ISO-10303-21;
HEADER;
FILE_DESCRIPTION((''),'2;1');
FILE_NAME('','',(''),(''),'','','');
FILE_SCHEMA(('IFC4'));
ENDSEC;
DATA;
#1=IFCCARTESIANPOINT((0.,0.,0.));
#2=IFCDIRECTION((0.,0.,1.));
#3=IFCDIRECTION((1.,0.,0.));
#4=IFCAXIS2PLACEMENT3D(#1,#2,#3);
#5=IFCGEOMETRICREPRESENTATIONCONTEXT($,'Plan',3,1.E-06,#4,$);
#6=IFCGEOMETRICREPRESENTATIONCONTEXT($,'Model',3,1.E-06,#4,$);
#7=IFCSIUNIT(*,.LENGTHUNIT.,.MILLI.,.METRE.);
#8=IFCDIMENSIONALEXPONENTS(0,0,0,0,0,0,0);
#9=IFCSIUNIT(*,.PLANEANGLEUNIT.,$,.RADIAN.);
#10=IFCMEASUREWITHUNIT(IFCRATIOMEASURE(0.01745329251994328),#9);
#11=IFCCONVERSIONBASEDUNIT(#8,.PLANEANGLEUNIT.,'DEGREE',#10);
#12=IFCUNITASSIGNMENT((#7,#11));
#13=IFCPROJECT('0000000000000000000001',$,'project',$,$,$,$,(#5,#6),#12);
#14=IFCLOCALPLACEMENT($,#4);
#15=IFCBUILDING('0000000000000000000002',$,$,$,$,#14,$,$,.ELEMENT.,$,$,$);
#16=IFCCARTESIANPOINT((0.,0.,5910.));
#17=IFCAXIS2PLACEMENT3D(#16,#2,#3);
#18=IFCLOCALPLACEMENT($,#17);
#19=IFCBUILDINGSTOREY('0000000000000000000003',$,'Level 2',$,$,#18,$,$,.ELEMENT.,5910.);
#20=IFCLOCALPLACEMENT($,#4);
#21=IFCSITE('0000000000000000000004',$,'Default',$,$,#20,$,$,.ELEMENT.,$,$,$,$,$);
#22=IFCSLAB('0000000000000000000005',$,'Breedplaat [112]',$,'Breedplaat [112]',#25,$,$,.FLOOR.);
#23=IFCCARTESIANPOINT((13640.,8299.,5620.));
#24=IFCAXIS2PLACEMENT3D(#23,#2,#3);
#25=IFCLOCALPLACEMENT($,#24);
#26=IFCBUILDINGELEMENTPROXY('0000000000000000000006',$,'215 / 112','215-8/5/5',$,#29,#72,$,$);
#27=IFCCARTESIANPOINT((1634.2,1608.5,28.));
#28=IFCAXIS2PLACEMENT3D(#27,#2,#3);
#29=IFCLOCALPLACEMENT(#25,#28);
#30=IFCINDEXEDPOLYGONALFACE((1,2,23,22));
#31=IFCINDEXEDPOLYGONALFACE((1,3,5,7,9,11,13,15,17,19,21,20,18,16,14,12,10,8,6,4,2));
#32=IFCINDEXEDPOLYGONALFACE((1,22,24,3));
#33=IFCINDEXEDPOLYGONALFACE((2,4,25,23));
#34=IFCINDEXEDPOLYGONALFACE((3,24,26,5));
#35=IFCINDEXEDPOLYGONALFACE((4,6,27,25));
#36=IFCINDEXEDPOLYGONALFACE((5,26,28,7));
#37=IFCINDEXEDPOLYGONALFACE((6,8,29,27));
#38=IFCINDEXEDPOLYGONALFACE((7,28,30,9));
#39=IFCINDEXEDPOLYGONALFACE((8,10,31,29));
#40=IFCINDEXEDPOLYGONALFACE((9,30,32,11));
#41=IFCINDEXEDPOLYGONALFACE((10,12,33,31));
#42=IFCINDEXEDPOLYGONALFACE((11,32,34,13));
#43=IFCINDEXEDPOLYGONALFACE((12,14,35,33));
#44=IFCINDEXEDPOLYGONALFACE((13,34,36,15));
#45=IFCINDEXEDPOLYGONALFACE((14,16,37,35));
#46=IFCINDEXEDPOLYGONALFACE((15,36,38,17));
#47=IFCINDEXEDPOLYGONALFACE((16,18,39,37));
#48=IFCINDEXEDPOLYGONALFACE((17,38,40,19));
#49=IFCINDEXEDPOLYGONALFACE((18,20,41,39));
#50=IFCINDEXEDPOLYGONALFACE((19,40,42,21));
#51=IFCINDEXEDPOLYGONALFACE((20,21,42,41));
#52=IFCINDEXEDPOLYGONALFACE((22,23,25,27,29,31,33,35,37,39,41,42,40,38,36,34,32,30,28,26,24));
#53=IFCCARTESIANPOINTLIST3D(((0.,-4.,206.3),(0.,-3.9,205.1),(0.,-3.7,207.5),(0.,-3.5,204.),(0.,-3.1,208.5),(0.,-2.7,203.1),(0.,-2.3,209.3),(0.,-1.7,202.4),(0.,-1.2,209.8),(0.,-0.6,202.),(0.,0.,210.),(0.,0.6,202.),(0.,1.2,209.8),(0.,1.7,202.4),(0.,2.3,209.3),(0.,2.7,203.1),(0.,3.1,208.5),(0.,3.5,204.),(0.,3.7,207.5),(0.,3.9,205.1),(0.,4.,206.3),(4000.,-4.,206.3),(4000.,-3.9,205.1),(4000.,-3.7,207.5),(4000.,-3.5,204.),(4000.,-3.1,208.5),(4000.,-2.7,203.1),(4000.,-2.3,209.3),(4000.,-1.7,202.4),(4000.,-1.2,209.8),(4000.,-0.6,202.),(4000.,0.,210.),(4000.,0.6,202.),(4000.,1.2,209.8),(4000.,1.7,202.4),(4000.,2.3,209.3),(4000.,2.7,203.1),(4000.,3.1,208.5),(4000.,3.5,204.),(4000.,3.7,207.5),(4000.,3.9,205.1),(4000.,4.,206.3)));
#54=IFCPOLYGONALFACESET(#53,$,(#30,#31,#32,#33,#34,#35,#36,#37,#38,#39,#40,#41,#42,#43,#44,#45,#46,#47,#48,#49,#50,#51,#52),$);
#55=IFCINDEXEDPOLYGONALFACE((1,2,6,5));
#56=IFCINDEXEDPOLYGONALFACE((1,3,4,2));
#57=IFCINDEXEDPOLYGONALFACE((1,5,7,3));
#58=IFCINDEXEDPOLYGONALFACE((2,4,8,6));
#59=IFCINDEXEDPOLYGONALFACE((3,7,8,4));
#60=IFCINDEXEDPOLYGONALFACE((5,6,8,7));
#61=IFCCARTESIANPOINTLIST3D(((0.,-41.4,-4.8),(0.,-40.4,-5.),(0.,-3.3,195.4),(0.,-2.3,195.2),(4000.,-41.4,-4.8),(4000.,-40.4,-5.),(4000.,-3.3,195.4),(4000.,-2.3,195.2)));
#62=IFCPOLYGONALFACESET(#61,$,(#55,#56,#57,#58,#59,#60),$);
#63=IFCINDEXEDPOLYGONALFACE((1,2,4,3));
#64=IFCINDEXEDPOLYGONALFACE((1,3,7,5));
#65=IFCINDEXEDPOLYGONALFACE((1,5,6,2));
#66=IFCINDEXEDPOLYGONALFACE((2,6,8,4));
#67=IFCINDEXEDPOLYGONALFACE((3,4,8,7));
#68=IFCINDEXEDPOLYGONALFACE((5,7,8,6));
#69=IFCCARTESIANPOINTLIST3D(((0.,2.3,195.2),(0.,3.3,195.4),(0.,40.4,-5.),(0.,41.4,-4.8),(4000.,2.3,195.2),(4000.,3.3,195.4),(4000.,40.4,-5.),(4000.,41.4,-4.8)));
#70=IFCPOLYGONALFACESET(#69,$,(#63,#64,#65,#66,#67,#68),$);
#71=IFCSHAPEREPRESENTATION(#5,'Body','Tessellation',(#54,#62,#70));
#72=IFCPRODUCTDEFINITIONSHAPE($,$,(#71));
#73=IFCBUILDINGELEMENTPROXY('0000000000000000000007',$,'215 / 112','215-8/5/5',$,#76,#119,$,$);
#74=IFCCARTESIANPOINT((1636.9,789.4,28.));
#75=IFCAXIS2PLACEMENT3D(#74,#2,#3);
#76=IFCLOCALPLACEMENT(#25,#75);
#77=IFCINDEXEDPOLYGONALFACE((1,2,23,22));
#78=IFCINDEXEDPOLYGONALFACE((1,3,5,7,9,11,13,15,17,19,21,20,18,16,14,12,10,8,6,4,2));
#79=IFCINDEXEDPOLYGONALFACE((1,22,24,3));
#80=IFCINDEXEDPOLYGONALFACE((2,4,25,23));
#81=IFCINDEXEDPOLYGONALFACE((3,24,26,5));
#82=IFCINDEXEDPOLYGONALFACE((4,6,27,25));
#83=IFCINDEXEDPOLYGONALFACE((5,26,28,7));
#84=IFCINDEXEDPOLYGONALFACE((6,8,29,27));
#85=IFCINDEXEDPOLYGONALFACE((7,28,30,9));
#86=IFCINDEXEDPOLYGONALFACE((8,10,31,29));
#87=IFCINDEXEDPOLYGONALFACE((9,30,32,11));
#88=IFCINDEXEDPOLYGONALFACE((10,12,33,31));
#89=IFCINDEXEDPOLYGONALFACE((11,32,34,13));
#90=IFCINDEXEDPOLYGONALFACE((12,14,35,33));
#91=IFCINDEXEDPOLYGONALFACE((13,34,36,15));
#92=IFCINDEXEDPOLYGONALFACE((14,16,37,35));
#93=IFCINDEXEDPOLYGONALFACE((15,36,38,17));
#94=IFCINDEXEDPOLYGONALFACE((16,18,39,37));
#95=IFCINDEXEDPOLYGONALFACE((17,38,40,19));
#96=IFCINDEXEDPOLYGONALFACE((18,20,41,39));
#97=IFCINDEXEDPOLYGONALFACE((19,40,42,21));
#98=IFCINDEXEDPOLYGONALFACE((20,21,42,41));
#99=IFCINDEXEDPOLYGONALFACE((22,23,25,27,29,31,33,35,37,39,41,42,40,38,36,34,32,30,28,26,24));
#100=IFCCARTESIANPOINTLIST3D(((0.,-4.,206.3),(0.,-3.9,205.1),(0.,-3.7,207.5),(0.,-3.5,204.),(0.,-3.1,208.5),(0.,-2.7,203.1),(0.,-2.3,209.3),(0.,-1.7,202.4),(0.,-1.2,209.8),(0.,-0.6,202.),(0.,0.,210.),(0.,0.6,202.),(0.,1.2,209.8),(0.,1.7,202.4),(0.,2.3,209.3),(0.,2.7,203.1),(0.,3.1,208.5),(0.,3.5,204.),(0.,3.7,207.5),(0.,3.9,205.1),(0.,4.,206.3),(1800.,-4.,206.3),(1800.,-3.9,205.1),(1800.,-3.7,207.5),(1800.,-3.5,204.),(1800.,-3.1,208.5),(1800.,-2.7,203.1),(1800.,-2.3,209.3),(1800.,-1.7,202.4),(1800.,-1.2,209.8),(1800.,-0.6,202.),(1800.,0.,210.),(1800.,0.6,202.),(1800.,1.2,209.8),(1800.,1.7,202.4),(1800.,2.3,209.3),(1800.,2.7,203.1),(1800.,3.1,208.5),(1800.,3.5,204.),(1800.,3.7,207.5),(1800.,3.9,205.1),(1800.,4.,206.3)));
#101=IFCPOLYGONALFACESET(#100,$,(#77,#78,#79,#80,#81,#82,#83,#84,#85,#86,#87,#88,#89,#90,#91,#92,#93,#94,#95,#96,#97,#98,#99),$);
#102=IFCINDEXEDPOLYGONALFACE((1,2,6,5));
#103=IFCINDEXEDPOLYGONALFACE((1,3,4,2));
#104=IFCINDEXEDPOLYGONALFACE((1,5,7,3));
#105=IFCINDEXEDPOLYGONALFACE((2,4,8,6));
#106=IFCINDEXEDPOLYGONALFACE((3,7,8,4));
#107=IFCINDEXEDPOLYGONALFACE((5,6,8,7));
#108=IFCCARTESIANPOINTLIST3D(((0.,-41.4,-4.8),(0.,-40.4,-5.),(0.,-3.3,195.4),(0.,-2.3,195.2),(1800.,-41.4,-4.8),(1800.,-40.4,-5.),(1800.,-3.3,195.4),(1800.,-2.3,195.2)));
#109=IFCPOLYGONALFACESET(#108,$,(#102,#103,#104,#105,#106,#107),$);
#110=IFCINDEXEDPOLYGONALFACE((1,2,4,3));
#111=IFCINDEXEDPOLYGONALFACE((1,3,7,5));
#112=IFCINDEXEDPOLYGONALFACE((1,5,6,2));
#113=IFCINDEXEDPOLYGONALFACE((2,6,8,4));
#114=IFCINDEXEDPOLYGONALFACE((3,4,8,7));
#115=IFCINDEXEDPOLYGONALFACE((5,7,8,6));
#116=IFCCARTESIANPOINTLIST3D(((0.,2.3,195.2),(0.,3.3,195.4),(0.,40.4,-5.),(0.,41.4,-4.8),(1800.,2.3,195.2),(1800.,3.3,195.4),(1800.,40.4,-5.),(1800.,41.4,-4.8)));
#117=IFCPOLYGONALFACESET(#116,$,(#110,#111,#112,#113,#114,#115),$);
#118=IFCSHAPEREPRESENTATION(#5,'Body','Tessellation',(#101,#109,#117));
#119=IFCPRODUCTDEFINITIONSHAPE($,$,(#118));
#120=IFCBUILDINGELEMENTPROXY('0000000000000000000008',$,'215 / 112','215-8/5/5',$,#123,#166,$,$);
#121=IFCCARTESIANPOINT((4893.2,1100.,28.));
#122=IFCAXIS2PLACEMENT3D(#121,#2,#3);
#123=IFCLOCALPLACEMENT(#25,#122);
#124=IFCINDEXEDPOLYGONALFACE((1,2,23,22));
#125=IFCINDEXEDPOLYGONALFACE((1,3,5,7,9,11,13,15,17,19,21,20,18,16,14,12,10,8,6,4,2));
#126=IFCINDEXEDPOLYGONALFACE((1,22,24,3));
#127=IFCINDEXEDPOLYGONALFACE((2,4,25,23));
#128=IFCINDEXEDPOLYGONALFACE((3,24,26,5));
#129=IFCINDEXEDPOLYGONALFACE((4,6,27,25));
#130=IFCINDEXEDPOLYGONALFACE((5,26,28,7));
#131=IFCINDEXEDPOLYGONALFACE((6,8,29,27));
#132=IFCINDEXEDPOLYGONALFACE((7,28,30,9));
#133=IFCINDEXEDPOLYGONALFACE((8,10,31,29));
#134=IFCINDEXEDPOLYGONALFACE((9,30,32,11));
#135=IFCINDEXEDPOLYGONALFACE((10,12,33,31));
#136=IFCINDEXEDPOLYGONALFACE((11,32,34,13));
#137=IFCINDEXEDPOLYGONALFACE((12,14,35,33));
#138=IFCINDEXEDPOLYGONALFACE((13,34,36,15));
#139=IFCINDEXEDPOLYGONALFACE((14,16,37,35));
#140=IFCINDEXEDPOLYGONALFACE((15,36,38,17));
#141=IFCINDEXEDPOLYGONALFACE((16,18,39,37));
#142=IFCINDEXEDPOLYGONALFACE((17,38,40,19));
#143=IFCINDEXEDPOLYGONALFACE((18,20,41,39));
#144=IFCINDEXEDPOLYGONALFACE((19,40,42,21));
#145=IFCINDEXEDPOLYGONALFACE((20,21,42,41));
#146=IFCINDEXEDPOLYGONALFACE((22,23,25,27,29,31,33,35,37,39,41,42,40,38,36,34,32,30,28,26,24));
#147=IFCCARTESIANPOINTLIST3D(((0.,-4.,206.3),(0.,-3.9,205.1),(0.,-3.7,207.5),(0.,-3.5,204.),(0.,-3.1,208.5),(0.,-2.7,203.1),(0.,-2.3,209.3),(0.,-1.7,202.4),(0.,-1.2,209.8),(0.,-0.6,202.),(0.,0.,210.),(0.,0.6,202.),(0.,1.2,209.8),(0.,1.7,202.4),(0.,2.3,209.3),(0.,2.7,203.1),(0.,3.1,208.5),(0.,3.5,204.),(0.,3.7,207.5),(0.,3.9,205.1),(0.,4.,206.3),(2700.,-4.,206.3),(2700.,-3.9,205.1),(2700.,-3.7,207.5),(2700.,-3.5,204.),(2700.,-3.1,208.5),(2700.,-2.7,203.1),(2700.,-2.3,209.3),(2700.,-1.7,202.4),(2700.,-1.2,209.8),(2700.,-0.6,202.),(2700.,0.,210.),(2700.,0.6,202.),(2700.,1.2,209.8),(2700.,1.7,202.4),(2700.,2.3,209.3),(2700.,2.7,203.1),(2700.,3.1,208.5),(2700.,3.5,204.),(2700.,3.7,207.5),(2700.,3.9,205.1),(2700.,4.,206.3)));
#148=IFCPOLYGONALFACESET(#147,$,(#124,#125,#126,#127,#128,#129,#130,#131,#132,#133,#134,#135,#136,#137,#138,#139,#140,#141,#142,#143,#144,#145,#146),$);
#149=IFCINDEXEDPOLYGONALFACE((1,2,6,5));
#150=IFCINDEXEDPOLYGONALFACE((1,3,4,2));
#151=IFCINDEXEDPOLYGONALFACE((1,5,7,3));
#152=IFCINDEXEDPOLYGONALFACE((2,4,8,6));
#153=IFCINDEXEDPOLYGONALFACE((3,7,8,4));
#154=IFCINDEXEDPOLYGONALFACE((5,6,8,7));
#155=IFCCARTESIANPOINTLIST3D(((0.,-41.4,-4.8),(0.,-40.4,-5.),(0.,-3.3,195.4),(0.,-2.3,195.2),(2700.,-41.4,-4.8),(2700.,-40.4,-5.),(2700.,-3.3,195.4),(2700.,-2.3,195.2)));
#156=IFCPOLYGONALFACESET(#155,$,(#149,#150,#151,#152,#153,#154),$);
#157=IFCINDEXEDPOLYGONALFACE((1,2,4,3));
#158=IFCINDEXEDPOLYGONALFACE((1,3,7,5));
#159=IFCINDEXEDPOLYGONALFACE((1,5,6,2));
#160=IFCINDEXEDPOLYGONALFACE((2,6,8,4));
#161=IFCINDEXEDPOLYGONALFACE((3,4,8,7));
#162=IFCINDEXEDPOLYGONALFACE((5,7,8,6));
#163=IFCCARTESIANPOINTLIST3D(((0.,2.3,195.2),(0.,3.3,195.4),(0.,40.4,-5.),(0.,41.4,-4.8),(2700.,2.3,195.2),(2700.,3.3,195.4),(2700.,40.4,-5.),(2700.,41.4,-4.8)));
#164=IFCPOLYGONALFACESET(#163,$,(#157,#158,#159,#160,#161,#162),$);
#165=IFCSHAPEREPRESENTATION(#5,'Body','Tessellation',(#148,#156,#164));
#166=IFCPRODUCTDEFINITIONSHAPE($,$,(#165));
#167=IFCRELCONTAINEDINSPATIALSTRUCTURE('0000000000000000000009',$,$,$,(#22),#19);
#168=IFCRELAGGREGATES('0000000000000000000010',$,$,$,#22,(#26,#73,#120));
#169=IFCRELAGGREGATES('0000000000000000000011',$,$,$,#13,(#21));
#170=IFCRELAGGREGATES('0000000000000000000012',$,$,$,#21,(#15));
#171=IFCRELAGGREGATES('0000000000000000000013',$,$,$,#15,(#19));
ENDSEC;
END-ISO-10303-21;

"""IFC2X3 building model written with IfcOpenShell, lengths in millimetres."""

from ifc_helpers import new_model, entity, si_unit, converted_unit, frame, origin_with_axes, origin_2d_with_axis, place, context, project, spatial, rectangle, circle, extrude, element, aggregate, save


model = new_model("IFC2X3")

# Units and contexts
plan_context = context("Plan", 3, precision=1e-06, world=origin_with_axes())
model_context = context("Model", 3, precision=1e-06, world=origin_with_axes())
ifc_project = project(units=[si_unit("LENGTHUNIT", "METRE", prefix="MILLI"), converted_unit("PLANEANGLEUNIT", "DEGREE", entity("IfcRatioMeasure", 0.01745329251994328), si_unit("PLANEANGLEUNIT", "RADIAN"), dimensions=[0, 0, 0, 0, 0, 0, 0])], contexts=[plan_context, model_context])

# Site, building, storey
site_placement = place(None, origin_with_axes())
site = spatial("IfcSite", under=ifc_project, at=site_placement, Name="Default", CompositionType="ELEMENT")
building_placement = place(None, origin_with_axes())
building = spatial("IfcBuilding", under=site, at=building_placement, CompositionType="ELEMENT")
storey_placement = place(None, frame((0.0, 0.0, 5910.0), z_axis=(0.0, 0.0, 1.0), x_axis=(1.0, 0.0, 0.0)))
storey = spatial("IfcBuildingStorey", under=building, at=storey_placement, Name="Level 2", CompositionType="ELEMENT", Elevation=5910.0)

# Slab, building element proxies
slab_1_placement = place(None, frame((13640.0, 8299.0, 5620.0), z_axis=(0.0, 0.0, 1.0), x_axis=(1.0, 0.0, 0.0)))
slab_1 = element("IfcSlab", 1, at=slab_1_placement, inside=storey, Name="Breedplaat [112]", ObjectType="Breedplaat [112]", PredefinedType="FLOOR")
proxy_1_placement = place(slab_1_placement, frame((1634.2, 1608.5, 28.0), z_axis=(0.0, 0.0, 1.0), x_axis=(1.0, 0.0, 0.0)))
proxy_1 = element("IfcBuildingElementProxy", 2, at=proxy_1_placement, Name="215 / 112", Description="215-8/5/5", context=plan_context, shape_type="SweptSolid", body=[
    extrude(circle(Radius=4.0, at=origin_2d_with_axis()), frame((0.0, 0.0, 206.0), z_axis=(1.0, 0.0, 0.0), x_axis=(0.0, 0.0, 1.0)), (0.0, 0.0, 1.0), 4000.0),
    extrude(rectangle(XDim=203.8, YDim=1.0, at=origin_2d_with_axis()), frame((0.0, -21.9, 95.2), z_axis=(1.0, 0.0, 0.0), x_axis=(0.0, 0.187112, 0.982339)), (0.0, 0.0, 1.0), 4000.0),
    extrude(rectangle(XDim=203.8, YDim=1.0, at=origin_2d_with_axis()), frame((0.0, 21.9, 95.2), z_axis=(1.0, 0.0, 0.0), x_axis=(0.0, -0.187112, 0.982339)), (0.0, 0.0, 1.0), 4000.0),
])
proxy_2_placement = place(slab_1_placement, frame((1636.9, 789.4, 28.0), z_axis=(0.0, 0.0, 1.0), x_axis=(1.0, 0.0, 0.0)))
proxy_2 = element("IfcBuildingElementProxy", 3, at=proxy_2_placement, Name="215 / 112", Description="215-8/5/5", context=plan_context, shape_type="SweptSolid", body=[
    extrude(circle(Radius=4.0, at=origin_2d_with_axis()), frame((0.0, 0.0, 206.0), z_axis=(1.0, 0.0, 0.0), x_axis=(0.0, 0.0, 1.0)), (0.0, 0.0, 1.0), 1800.0),
    extrude(rectangle(XDim=203.8, YDim=1.0, at=origin_2d_with_axis()), frame((0.0, -21.9, 95.2), z_axis=(1.0, 0.0, 0.0), x_axis=(0.0, 0.187112, 0.982339)), (0.0, 0.0, 1.0), 1800.0),
    extrude(rectangle(XDim=203.8, YDim=1.0, at=origin_2d_with_axis()), frame((0.0, 21.9, 95.2), z_axis=(1.0, 0.0, 0.0), x_axis=(0.0, -0.187112, 0.982339)), (0.0, 0.0, 1.0), 1800.0),
])
proxy_3_placement = place(slab_1_placement, frame((4893.2, 1100.0, 28.0), z_axis=(0.0, 0.0, 1.0), x_axis=(1.0, 0.0, 0.0)))
proxy_3 = element("IfcBuildingElementProxy", 4, at=proxy_3_placement, Name="215 / 112", Description="215-8/5/5", context=plan_context, shape_type="SweptSolid", body=[
    extrude(circle(Radius=4.0, at=origin_2d_with_axis()), frame((0.0, 0.0, 206.0), z_axis=(1.0, 0.0, 0.0), x_axis=(0.0, 0.0, 1.0)), (0.0, 0.0, 1.0), 2700.0),
    extrude(rectangle(XDim=203.8, YDim=1.0, at=origin_2d_with_axis()), frame((0.0, -21.9, 95.2), z_axis=(1.0, 0.0, 0.0), x_axis=(0.0, 0.187112, 0.982339)), (0.0, 0.0, 1.0), 2700.0),
    extrude(rectangle(XDim=203.8, YDim=1.0, at=origin_2d_with_axis()), frame((0.0, 21.9, 95.2), z_axis=(1.0, 0.0, 0.0), x_axis=(0.0, -0.187112, 0.982339)), (0.0, 0.0, 1.0), 2700.0),
])
aggregate(slab_1, [proxy_1, proxy_2, proxy_3])

save(model, "model.ifc")
